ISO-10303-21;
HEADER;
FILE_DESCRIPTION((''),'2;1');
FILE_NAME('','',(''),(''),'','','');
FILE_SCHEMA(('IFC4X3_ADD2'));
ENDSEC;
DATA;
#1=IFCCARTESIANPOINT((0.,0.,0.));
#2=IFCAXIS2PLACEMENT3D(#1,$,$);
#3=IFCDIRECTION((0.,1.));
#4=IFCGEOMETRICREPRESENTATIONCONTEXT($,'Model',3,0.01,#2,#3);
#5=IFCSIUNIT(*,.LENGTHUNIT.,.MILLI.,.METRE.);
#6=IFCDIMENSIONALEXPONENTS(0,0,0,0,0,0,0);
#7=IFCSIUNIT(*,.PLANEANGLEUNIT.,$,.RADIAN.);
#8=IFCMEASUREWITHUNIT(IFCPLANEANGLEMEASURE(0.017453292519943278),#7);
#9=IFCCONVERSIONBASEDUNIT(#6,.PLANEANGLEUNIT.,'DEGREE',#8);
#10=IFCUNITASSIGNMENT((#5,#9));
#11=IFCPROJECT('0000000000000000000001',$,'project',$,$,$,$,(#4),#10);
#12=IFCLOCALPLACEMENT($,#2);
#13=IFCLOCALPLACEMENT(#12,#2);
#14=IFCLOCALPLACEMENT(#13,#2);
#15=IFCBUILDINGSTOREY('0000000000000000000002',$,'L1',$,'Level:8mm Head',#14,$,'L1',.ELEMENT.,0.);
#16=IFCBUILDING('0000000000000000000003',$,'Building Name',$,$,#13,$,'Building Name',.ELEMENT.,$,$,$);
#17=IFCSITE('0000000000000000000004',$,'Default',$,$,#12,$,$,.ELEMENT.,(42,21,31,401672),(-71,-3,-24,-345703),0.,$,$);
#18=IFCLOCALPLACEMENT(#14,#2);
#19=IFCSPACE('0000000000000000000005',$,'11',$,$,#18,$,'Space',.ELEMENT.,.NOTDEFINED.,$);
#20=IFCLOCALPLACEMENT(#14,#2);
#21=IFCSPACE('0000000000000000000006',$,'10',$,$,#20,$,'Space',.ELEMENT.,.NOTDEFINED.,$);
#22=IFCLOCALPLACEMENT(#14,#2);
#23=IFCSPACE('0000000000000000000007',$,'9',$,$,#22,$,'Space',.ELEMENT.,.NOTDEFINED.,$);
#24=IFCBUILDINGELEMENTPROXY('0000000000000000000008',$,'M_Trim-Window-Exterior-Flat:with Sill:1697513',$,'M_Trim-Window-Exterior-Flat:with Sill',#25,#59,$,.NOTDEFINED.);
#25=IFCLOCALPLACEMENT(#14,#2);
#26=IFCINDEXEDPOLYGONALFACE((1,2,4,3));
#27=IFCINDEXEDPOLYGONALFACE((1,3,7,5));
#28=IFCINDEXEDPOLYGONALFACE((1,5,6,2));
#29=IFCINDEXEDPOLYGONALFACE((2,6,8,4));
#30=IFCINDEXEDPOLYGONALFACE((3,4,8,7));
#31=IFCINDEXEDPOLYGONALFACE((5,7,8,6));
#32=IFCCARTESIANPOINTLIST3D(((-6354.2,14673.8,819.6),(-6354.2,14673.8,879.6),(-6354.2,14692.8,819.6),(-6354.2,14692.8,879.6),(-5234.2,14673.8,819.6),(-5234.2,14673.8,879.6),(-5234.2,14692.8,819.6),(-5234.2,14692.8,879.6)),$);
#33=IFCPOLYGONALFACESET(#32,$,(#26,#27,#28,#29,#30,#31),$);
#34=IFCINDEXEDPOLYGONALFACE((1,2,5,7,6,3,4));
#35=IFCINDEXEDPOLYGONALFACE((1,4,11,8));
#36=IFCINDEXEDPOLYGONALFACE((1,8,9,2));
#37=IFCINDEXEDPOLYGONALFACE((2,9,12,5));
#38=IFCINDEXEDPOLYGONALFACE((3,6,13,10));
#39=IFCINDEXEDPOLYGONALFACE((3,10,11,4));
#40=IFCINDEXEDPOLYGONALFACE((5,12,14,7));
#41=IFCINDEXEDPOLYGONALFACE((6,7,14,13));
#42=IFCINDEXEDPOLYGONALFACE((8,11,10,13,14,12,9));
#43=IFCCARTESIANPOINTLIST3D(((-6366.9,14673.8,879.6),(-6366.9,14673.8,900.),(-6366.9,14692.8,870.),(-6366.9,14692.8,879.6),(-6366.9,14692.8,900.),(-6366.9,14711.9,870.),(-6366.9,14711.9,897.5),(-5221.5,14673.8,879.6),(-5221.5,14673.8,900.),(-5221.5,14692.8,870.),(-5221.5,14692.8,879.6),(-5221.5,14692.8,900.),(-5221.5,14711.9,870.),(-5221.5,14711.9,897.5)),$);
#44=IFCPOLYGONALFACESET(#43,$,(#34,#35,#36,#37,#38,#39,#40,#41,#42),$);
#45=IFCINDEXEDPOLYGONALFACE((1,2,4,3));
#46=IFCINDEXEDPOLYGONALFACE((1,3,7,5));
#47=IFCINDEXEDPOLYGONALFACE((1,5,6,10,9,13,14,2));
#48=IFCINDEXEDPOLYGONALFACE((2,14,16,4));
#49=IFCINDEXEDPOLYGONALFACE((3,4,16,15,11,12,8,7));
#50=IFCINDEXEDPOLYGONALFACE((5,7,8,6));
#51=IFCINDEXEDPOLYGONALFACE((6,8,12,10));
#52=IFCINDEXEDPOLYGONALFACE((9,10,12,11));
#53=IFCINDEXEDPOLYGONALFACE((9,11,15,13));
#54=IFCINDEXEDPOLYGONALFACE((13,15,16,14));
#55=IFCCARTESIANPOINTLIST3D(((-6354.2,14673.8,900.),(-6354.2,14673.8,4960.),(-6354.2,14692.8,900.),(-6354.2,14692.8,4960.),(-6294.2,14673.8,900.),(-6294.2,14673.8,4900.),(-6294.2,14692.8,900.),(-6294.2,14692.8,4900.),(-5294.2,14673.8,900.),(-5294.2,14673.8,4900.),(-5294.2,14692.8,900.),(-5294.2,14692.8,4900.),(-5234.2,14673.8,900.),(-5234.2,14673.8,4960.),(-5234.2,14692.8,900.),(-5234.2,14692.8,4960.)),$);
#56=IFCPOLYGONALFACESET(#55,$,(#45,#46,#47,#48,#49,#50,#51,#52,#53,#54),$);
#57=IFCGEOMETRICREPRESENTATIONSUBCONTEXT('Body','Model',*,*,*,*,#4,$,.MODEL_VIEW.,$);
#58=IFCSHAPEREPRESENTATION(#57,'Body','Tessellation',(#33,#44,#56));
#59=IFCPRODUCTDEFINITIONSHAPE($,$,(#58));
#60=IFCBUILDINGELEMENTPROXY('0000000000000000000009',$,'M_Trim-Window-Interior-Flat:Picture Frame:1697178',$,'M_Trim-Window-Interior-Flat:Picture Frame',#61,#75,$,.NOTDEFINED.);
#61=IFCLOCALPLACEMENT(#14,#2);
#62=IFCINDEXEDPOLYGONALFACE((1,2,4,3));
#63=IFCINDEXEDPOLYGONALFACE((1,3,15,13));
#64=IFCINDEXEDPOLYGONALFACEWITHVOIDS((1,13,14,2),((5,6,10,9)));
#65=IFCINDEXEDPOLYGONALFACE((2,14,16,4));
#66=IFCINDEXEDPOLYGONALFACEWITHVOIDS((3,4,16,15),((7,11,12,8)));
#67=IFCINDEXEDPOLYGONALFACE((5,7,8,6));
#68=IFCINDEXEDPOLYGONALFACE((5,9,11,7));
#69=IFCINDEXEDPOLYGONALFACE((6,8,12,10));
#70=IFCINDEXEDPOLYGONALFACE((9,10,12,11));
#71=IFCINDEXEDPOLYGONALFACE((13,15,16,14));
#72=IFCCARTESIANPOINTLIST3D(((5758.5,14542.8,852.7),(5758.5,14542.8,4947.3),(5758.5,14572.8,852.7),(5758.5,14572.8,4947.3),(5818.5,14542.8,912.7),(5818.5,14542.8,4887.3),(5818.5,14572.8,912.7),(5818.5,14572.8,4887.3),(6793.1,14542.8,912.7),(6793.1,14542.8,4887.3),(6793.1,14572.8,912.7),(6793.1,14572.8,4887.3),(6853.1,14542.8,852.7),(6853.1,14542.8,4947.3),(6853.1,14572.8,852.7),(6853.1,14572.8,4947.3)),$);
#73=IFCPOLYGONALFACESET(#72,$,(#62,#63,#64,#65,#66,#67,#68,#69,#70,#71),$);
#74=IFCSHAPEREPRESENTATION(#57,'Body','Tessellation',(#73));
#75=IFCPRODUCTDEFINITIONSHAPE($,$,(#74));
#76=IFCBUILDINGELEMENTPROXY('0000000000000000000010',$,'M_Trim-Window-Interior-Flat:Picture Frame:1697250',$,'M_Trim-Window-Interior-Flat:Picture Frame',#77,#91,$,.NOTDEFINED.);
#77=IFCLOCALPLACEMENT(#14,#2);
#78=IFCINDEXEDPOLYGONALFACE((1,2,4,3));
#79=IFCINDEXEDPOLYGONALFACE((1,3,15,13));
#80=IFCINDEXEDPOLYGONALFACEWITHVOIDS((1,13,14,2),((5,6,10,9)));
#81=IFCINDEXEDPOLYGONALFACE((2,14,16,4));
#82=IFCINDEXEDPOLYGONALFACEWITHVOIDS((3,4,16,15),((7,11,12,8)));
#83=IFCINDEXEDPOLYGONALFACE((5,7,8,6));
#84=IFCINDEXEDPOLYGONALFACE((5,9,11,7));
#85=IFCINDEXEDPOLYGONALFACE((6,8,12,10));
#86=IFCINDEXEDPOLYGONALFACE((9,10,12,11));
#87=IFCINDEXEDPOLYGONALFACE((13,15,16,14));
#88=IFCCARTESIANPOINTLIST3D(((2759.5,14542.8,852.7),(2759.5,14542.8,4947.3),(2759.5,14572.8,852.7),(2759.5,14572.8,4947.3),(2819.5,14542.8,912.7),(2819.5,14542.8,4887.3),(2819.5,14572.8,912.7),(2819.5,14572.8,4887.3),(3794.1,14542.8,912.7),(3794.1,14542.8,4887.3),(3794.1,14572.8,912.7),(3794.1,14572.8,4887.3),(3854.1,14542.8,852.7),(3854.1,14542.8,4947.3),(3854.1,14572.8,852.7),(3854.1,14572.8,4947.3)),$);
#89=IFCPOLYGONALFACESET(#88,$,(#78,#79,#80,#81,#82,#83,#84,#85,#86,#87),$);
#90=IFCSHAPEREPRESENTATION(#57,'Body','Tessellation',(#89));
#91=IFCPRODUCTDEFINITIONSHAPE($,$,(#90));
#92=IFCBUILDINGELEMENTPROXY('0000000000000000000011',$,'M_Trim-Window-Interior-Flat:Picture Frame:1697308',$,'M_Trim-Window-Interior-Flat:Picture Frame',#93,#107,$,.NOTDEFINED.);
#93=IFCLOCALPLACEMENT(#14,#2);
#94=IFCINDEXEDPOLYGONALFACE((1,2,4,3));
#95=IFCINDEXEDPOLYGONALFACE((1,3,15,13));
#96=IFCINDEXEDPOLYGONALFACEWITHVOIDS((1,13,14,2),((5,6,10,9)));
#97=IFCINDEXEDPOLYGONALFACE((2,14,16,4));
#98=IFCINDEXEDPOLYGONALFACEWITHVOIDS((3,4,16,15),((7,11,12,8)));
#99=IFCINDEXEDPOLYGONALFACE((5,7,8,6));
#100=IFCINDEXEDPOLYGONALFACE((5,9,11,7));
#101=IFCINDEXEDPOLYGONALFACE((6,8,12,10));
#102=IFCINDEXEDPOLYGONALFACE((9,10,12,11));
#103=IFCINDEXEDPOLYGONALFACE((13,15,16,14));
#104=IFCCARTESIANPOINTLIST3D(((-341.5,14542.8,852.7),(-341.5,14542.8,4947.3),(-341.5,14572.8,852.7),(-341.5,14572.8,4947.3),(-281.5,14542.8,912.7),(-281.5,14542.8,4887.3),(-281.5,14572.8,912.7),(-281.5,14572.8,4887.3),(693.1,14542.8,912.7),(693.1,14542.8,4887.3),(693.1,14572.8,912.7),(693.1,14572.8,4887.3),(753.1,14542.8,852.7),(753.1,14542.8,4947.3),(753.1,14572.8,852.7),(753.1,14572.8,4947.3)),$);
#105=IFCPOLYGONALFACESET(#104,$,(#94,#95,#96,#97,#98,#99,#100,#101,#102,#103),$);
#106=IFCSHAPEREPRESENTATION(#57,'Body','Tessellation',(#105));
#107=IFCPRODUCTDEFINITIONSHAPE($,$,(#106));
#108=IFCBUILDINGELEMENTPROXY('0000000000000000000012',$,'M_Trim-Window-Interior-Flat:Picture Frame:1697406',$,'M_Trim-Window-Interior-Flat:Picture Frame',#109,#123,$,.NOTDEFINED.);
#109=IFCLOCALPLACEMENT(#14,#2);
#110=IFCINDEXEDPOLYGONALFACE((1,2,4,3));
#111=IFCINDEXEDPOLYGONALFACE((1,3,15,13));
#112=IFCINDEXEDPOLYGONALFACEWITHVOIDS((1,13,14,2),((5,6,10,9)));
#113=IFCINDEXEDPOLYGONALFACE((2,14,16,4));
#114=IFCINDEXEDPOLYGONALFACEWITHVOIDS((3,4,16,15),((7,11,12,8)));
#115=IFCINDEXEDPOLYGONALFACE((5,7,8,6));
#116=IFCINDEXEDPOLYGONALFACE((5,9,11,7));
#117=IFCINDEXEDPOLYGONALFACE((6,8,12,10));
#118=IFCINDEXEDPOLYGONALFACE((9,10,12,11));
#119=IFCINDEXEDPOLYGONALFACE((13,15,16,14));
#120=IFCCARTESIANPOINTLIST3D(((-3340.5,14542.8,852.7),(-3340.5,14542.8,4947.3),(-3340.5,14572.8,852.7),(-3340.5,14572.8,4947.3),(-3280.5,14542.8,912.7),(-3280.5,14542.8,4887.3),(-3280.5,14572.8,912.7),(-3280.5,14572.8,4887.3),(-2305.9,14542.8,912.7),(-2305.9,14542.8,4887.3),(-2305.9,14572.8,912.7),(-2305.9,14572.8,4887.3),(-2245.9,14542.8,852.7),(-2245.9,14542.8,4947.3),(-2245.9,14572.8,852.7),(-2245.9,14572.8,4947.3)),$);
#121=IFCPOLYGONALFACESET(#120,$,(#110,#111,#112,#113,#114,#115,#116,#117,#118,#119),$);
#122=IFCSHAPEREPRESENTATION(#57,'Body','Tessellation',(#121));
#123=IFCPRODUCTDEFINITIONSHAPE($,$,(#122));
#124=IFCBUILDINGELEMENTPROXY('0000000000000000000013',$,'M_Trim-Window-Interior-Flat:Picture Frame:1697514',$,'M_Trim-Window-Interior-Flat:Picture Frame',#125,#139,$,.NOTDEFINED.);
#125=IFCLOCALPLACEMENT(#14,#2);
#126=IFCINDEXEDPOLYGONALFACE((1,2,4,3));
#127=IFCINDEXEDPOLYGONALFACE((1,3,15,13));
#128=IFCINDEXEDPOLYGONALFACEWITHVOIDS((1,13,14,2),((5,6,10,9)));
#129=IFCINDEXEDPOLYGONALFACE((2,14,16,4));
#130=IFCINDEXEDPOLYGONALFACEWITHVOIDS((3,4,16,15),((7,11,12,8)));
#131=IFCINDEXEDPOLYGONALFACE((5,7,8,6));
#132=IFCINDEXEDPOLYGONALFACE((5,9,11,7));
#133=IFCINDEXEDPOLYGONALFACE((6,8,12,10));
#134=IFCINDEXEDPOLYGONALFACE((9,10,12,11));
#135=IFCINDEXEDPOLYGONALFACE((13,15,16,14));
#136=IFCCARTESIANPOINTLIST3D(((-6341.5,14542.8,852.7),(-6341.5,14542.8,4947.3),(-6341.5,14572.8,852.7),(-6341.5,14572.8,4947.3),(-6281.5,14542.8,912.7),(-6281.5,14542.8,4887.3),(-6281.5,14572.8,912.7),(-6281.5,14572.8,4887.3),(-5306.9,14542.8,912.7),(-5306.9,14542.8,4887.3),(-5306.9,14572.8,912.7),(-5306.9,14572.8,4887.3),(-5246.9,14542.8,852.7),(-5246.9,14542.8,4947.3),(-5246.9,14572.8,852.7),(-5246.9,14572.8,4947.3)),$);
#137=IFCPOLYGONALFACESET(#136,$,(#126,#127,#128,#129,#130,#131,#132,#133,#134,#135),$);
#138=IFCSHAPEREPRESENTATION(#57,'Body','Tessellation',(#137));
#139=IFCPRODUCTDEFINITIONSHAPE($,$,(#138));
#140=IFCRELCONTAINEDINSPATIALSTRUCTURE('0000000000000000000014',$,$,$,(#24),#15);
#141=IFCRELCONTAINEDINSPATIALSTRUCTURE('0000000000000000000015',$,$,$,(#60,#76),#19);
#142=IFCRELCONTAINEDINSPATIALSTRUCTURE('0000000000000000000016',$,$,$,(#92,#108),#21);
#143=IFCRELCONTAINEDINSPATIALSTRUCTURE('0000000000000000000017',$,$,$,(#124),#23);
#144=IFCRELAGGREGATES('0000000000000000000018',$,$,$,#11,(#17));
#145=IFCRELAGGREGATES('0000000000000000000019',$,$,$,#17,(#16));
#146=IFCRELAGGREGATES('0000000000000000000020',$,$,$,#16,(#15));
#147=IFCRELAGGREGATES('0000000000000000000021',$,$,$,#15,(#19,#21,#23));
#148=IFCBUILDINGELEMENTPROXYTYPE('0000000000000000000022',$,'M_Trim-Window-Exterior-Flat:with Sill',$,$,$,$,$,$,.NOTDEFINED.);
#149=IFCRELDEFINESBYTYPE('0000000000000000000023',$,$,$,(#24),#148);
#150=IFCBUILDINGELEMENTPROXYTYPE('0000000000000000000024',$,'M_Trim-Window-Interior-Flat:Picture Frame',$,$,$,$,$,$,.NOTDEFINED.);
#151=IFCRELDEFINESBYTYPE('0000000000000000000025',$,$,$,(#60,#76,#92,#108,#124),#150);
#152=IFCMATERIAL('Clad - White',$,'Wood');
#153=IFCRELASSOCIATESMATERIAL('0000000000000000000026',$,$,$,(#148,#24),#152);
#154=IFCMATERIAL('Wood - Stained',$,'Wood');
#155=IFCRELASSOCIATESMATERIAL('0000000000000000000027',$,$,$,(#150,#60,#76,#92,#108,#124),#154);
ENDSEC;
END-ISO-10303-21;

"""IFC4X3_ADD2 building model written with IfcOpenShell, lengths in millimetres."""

from ifc_helpers import new_model, entity, si_unit, converted_unit, direction, frame, frame_2d, origin, place, context, subcontext, project, spatial, polyline, rectangle, outline, extrude, source, transform, mapped, material, type_object, type_shapes, element, save


model = new_model("IFC4X3_ADD2")

# Units and contexts
model_context = context("Model", 3, precision=0.01, world=origin(), true_north=direction((0.0, 1.0)))
body_context = subcontext(model_context, "Body", "Model", "MODEL_VIEW")
ifc_project = project(units=[si_unit("LENGTHUNIT", "METRE", prefix="MILLI"), converted_unit("PLANEANGLEUNIT", "DEGREE", entity("IfcPlaneAngleMeasure", 0.017453292519943278), si_unit("PLANEANGLEUNIT", "RADIAN"), dimensions=[0, 0, 0, 0, 0, 0, 0])], contexts=[model_context])

# Site, building, storey
site_placement = place(None, origin())
site = spatial("IfcSite", under=ifc_project, at=site_placement, Name="Default", CompositionType="ELEMENT", RefLatitude=(42, 21, 31, 401672), RefLongitude=(-71, -3, -24, -345703), RefElevation=0.0)
building_placement = place(site_placement, origin())
building = spatial("IfcBuilding", under=site, at=building_placement, Name="Building Name", LongName="Building Name", CompositionType="ELEMENT")
storey_placement = place(building_placement, origin())
storey = spatial("IfcBuildingStorey", under=building, at=storey_placement, Name="L1", ObjectType="Level:8mm Head", LongName="L1", CompositionType="ELEMENT", Elevation=0.0)

# Building element proxy
ifc_material_1 = material(Name="Clad - White", Category="Wood")
ifc_material_2 = material(Name="Wood - Stained", Category="Wood")
building_element_proxy_type_1 = type_object("IfcBuildingElementProxyType", Name="M_Trim-Window-Exterior-Flat:with Sill", PredefinedType="NOTDEFINED", material=ifc_material_1)
shared_shape_1 = source(origin(), body_context, "Body", "SweptSolid", [
    extrude(rectangle(XDim=1120.0, YDim=60.0, at=frame_2d((0.0, 0.0), x_axis=(1.0, 0.0))), frame((0.0, -4050.4, 0.0), z_axis=(0.0, 0.0, 1.0), x_axis=(-1.0, 0.0, 0.0)), (0.0, 0.0, 1.0), 19.0),
    extrude(outline(polyline([(-19.0, -15.2), (0.0, -15.2), (0.0, -5.7), (19.0, -5.7), (19.0, 14.8), (0.0, 14.8), (-19.0, 12.3), (-19.0, -15.2)])), frame((-572.7, -4014.8, 19.0), z_axis=(1.0, 0.0, 0.0), x_axis=(0.0, 0.0, -1.0)), (0.0, 0.0, 1.0), 1145.4),
    extrude(outline(polyline([(-2045.0, -560.0), (2015.0, -560.0), (2015.0, -500.0), (-1985.0, -500.0), (-1985.0, 500.0), (2015.0, 500.0), (2015.0, 560.0), (-2045.0, 560.0), (-2045.0, -560.0)])), frame((0.0, -1985.0, 0.0), z_axis=(0.0, 0.0, 1.0), x_axis=(0.0, -1.0, 0.0)), (0.0, 0.0, 1.0), 19.0),
])
type_shapes(building_element_proxy_type_1, [shared_shape_1])
for number, where, z_axis, x_axis, name in (
    (1, (-5794.2, 14673.8, 4900.0), (0.0, 1.0, 0.0), (-1.0, 0.0, 0.0), "M_Trim-Window-Exterior-Flat:with Sill:1697513"),
):
    element("IfcBuildingElementProxy", number, at=place(storey_placement, frame(where, z_axis=z_axis, x_axis=x_axis)), inside=storey, type_object=building_element_proxy_type_1, material=ifc_material_1, Name=name, ObjectType="M_Trim-Window-Exterior-Flat:with Sill", PredefinedType="NOTDEFINED", context=body_context, shape_type="MappedRepresentation", body=[
        mapped(shared_shape_1, transform((0.0, 0.0, 0.0), scale=1.0)),
    ])

# Shared definitions
space_1_placement = place(storey_placement, origin())
space_1 = spatial("IfcSpace", under=storey, at=space_1_placement, Name="11", LongName="Space", CompositionType="ELEMENT", PredefinedType="NOTDEFINED")

# Building element proxies
building_element_proxy_type_2 = type_object("IfcBuildingElementProxyType", Name="M_Trim-Window-Interior-Flat:Picture Frame", PredefinedType="NOTDEFINED", material=ifc_material_2)
shared_shape_2 = source(origin(), body_context, "Body", "SweptSolid", [
    extrude(outline(polyline([(-547.3, -2047.3), (547.3, -2047.3), (547.3, 2047.3), (-547.3, 2047.3), (-547.3, -2047.3)]), holes=[polyline([(-487.3, -1987.3), (-487.3, 1987.3), (487.3, 1987.3), (487.3, -1987.3), (-487.3, -1987.3)])]), frame((0.0, -2000.0, 0.0), z_axis=(0.0, 0.0, 1.0), x_axis=(-1.0, 0.0, 0.0)), (0.0, 0.0, 1.0), 30.0),
])
type_shapes(building_element_proxy_type_2, [shared_shape_2])
for number, where, z_axis, x_axis, name in (
    (2, (6305.8, 14572.8, 4900.0), (0.0, -1.0, 0.0), (1.0, 0.0, 0.0), "M_Trim-Window-Interior-Flat:Picture Frame:1697178"),
    (3, (3306.8, 14572.8, 4900.0), (0.0, -1.0, 0.0), (1.0, 0.0, 0.0), "M_Trim-Window-Interior-Flat:Picture Frame:1697250"),
):
    element("IfcBuildingElementProxy", number, at=place(space_1_placement, frame(where, z_axis=z_axis, x_axis=x_axis)), inside=space_1, type_object=building_element_proxy_type_2, material=ifc_material_2, Name=name, ObjectType="M_Trim-Window-Interior-Flat:Picture Frame", PredefinedType="NOTDEFINED", context=body_context, shape_type="MappedRepresentation", body=[
        mapped(shared_shape_2, transform((0.0, 0.0, 0.0), scale=1.0)),
    ])

# Shared definitions
space_2_placement = place(storey_placement, origin())
space_2 = spatial("IfcSpace", under=storey, at=space_2_placement, Name="10", LongName="Space", CompositionType="ELEMENT", PredefinedType="NOTDEFINED")

# Building element proxies
for number, where, z_axis, x_axis, name in (
    (4, (205.8, 14572.8, 4900.0), (0.0, -1.0, 0.0), (1.0, 0.0, 0.0), "M_Trim-Window-Interior-Flat:Picture Frame:1697308"),
    (5, (-2793.2, 14572.8, 4900.0), (0.0, -1.0, 0.0), (1.0, 0.0, 0.0), "M_Trim-Window-Interior-Flat:Picture Frame:1697406"),
):
    element("IfcBuildingElementProxy", number, at=place(space_2_placement, frame(where, z_axis=z_axis, x_axis=x_axis)), inside=space_2, type_object=building_element_proxy_type_2, material=ifc_material_2, Name=name, ObjectType="M_Trim-Window-Interior-Flat:Picture Frame", PredefinedType="NOTDEFINED", context=body_context, shape_type="MappedRepresentation", body=[
        mapped(shared_shape_2, transform((0.0, 0.0, 0.0), scale=1.0)),
    ])

# Shared definitions
space_3_placement = place(storey_placement, origin())
space_3 = spatial("IfcSpace", under=storey, at=space_3_placement, Name="9", LongName="Space", CompositionType="ELEMENT", PredefinedType="NOTDEFINED")

# Building element proxy
proxy_1_placement = place(space_3_placement, frame((-5794.2, 14572.8, 4900.0), z_axis=(0.0, -1.0, 0.0), x_axis=(1.0, 0.0, 0.0)))
element("IfcBuildingElementProxy", 6, at=proxy_1_placement, inside=space_3, type_object=building_element_proxy_type_2, material=ifc_material_2, Name="M_Trim-Window-Interior-Flat:Picture Frame:1697514", ObjectType="M_Trim-Window-Interior-Flat:Picture Frame", PredefinedType="NOTDEFINED", context=body_context, shape_type="MappedRepresentation", body=[
    mapped(shared_shape_2, transform((0.0, 0.0, 0.0), scale=1.0)),
])

save(model, "model.ifc")
